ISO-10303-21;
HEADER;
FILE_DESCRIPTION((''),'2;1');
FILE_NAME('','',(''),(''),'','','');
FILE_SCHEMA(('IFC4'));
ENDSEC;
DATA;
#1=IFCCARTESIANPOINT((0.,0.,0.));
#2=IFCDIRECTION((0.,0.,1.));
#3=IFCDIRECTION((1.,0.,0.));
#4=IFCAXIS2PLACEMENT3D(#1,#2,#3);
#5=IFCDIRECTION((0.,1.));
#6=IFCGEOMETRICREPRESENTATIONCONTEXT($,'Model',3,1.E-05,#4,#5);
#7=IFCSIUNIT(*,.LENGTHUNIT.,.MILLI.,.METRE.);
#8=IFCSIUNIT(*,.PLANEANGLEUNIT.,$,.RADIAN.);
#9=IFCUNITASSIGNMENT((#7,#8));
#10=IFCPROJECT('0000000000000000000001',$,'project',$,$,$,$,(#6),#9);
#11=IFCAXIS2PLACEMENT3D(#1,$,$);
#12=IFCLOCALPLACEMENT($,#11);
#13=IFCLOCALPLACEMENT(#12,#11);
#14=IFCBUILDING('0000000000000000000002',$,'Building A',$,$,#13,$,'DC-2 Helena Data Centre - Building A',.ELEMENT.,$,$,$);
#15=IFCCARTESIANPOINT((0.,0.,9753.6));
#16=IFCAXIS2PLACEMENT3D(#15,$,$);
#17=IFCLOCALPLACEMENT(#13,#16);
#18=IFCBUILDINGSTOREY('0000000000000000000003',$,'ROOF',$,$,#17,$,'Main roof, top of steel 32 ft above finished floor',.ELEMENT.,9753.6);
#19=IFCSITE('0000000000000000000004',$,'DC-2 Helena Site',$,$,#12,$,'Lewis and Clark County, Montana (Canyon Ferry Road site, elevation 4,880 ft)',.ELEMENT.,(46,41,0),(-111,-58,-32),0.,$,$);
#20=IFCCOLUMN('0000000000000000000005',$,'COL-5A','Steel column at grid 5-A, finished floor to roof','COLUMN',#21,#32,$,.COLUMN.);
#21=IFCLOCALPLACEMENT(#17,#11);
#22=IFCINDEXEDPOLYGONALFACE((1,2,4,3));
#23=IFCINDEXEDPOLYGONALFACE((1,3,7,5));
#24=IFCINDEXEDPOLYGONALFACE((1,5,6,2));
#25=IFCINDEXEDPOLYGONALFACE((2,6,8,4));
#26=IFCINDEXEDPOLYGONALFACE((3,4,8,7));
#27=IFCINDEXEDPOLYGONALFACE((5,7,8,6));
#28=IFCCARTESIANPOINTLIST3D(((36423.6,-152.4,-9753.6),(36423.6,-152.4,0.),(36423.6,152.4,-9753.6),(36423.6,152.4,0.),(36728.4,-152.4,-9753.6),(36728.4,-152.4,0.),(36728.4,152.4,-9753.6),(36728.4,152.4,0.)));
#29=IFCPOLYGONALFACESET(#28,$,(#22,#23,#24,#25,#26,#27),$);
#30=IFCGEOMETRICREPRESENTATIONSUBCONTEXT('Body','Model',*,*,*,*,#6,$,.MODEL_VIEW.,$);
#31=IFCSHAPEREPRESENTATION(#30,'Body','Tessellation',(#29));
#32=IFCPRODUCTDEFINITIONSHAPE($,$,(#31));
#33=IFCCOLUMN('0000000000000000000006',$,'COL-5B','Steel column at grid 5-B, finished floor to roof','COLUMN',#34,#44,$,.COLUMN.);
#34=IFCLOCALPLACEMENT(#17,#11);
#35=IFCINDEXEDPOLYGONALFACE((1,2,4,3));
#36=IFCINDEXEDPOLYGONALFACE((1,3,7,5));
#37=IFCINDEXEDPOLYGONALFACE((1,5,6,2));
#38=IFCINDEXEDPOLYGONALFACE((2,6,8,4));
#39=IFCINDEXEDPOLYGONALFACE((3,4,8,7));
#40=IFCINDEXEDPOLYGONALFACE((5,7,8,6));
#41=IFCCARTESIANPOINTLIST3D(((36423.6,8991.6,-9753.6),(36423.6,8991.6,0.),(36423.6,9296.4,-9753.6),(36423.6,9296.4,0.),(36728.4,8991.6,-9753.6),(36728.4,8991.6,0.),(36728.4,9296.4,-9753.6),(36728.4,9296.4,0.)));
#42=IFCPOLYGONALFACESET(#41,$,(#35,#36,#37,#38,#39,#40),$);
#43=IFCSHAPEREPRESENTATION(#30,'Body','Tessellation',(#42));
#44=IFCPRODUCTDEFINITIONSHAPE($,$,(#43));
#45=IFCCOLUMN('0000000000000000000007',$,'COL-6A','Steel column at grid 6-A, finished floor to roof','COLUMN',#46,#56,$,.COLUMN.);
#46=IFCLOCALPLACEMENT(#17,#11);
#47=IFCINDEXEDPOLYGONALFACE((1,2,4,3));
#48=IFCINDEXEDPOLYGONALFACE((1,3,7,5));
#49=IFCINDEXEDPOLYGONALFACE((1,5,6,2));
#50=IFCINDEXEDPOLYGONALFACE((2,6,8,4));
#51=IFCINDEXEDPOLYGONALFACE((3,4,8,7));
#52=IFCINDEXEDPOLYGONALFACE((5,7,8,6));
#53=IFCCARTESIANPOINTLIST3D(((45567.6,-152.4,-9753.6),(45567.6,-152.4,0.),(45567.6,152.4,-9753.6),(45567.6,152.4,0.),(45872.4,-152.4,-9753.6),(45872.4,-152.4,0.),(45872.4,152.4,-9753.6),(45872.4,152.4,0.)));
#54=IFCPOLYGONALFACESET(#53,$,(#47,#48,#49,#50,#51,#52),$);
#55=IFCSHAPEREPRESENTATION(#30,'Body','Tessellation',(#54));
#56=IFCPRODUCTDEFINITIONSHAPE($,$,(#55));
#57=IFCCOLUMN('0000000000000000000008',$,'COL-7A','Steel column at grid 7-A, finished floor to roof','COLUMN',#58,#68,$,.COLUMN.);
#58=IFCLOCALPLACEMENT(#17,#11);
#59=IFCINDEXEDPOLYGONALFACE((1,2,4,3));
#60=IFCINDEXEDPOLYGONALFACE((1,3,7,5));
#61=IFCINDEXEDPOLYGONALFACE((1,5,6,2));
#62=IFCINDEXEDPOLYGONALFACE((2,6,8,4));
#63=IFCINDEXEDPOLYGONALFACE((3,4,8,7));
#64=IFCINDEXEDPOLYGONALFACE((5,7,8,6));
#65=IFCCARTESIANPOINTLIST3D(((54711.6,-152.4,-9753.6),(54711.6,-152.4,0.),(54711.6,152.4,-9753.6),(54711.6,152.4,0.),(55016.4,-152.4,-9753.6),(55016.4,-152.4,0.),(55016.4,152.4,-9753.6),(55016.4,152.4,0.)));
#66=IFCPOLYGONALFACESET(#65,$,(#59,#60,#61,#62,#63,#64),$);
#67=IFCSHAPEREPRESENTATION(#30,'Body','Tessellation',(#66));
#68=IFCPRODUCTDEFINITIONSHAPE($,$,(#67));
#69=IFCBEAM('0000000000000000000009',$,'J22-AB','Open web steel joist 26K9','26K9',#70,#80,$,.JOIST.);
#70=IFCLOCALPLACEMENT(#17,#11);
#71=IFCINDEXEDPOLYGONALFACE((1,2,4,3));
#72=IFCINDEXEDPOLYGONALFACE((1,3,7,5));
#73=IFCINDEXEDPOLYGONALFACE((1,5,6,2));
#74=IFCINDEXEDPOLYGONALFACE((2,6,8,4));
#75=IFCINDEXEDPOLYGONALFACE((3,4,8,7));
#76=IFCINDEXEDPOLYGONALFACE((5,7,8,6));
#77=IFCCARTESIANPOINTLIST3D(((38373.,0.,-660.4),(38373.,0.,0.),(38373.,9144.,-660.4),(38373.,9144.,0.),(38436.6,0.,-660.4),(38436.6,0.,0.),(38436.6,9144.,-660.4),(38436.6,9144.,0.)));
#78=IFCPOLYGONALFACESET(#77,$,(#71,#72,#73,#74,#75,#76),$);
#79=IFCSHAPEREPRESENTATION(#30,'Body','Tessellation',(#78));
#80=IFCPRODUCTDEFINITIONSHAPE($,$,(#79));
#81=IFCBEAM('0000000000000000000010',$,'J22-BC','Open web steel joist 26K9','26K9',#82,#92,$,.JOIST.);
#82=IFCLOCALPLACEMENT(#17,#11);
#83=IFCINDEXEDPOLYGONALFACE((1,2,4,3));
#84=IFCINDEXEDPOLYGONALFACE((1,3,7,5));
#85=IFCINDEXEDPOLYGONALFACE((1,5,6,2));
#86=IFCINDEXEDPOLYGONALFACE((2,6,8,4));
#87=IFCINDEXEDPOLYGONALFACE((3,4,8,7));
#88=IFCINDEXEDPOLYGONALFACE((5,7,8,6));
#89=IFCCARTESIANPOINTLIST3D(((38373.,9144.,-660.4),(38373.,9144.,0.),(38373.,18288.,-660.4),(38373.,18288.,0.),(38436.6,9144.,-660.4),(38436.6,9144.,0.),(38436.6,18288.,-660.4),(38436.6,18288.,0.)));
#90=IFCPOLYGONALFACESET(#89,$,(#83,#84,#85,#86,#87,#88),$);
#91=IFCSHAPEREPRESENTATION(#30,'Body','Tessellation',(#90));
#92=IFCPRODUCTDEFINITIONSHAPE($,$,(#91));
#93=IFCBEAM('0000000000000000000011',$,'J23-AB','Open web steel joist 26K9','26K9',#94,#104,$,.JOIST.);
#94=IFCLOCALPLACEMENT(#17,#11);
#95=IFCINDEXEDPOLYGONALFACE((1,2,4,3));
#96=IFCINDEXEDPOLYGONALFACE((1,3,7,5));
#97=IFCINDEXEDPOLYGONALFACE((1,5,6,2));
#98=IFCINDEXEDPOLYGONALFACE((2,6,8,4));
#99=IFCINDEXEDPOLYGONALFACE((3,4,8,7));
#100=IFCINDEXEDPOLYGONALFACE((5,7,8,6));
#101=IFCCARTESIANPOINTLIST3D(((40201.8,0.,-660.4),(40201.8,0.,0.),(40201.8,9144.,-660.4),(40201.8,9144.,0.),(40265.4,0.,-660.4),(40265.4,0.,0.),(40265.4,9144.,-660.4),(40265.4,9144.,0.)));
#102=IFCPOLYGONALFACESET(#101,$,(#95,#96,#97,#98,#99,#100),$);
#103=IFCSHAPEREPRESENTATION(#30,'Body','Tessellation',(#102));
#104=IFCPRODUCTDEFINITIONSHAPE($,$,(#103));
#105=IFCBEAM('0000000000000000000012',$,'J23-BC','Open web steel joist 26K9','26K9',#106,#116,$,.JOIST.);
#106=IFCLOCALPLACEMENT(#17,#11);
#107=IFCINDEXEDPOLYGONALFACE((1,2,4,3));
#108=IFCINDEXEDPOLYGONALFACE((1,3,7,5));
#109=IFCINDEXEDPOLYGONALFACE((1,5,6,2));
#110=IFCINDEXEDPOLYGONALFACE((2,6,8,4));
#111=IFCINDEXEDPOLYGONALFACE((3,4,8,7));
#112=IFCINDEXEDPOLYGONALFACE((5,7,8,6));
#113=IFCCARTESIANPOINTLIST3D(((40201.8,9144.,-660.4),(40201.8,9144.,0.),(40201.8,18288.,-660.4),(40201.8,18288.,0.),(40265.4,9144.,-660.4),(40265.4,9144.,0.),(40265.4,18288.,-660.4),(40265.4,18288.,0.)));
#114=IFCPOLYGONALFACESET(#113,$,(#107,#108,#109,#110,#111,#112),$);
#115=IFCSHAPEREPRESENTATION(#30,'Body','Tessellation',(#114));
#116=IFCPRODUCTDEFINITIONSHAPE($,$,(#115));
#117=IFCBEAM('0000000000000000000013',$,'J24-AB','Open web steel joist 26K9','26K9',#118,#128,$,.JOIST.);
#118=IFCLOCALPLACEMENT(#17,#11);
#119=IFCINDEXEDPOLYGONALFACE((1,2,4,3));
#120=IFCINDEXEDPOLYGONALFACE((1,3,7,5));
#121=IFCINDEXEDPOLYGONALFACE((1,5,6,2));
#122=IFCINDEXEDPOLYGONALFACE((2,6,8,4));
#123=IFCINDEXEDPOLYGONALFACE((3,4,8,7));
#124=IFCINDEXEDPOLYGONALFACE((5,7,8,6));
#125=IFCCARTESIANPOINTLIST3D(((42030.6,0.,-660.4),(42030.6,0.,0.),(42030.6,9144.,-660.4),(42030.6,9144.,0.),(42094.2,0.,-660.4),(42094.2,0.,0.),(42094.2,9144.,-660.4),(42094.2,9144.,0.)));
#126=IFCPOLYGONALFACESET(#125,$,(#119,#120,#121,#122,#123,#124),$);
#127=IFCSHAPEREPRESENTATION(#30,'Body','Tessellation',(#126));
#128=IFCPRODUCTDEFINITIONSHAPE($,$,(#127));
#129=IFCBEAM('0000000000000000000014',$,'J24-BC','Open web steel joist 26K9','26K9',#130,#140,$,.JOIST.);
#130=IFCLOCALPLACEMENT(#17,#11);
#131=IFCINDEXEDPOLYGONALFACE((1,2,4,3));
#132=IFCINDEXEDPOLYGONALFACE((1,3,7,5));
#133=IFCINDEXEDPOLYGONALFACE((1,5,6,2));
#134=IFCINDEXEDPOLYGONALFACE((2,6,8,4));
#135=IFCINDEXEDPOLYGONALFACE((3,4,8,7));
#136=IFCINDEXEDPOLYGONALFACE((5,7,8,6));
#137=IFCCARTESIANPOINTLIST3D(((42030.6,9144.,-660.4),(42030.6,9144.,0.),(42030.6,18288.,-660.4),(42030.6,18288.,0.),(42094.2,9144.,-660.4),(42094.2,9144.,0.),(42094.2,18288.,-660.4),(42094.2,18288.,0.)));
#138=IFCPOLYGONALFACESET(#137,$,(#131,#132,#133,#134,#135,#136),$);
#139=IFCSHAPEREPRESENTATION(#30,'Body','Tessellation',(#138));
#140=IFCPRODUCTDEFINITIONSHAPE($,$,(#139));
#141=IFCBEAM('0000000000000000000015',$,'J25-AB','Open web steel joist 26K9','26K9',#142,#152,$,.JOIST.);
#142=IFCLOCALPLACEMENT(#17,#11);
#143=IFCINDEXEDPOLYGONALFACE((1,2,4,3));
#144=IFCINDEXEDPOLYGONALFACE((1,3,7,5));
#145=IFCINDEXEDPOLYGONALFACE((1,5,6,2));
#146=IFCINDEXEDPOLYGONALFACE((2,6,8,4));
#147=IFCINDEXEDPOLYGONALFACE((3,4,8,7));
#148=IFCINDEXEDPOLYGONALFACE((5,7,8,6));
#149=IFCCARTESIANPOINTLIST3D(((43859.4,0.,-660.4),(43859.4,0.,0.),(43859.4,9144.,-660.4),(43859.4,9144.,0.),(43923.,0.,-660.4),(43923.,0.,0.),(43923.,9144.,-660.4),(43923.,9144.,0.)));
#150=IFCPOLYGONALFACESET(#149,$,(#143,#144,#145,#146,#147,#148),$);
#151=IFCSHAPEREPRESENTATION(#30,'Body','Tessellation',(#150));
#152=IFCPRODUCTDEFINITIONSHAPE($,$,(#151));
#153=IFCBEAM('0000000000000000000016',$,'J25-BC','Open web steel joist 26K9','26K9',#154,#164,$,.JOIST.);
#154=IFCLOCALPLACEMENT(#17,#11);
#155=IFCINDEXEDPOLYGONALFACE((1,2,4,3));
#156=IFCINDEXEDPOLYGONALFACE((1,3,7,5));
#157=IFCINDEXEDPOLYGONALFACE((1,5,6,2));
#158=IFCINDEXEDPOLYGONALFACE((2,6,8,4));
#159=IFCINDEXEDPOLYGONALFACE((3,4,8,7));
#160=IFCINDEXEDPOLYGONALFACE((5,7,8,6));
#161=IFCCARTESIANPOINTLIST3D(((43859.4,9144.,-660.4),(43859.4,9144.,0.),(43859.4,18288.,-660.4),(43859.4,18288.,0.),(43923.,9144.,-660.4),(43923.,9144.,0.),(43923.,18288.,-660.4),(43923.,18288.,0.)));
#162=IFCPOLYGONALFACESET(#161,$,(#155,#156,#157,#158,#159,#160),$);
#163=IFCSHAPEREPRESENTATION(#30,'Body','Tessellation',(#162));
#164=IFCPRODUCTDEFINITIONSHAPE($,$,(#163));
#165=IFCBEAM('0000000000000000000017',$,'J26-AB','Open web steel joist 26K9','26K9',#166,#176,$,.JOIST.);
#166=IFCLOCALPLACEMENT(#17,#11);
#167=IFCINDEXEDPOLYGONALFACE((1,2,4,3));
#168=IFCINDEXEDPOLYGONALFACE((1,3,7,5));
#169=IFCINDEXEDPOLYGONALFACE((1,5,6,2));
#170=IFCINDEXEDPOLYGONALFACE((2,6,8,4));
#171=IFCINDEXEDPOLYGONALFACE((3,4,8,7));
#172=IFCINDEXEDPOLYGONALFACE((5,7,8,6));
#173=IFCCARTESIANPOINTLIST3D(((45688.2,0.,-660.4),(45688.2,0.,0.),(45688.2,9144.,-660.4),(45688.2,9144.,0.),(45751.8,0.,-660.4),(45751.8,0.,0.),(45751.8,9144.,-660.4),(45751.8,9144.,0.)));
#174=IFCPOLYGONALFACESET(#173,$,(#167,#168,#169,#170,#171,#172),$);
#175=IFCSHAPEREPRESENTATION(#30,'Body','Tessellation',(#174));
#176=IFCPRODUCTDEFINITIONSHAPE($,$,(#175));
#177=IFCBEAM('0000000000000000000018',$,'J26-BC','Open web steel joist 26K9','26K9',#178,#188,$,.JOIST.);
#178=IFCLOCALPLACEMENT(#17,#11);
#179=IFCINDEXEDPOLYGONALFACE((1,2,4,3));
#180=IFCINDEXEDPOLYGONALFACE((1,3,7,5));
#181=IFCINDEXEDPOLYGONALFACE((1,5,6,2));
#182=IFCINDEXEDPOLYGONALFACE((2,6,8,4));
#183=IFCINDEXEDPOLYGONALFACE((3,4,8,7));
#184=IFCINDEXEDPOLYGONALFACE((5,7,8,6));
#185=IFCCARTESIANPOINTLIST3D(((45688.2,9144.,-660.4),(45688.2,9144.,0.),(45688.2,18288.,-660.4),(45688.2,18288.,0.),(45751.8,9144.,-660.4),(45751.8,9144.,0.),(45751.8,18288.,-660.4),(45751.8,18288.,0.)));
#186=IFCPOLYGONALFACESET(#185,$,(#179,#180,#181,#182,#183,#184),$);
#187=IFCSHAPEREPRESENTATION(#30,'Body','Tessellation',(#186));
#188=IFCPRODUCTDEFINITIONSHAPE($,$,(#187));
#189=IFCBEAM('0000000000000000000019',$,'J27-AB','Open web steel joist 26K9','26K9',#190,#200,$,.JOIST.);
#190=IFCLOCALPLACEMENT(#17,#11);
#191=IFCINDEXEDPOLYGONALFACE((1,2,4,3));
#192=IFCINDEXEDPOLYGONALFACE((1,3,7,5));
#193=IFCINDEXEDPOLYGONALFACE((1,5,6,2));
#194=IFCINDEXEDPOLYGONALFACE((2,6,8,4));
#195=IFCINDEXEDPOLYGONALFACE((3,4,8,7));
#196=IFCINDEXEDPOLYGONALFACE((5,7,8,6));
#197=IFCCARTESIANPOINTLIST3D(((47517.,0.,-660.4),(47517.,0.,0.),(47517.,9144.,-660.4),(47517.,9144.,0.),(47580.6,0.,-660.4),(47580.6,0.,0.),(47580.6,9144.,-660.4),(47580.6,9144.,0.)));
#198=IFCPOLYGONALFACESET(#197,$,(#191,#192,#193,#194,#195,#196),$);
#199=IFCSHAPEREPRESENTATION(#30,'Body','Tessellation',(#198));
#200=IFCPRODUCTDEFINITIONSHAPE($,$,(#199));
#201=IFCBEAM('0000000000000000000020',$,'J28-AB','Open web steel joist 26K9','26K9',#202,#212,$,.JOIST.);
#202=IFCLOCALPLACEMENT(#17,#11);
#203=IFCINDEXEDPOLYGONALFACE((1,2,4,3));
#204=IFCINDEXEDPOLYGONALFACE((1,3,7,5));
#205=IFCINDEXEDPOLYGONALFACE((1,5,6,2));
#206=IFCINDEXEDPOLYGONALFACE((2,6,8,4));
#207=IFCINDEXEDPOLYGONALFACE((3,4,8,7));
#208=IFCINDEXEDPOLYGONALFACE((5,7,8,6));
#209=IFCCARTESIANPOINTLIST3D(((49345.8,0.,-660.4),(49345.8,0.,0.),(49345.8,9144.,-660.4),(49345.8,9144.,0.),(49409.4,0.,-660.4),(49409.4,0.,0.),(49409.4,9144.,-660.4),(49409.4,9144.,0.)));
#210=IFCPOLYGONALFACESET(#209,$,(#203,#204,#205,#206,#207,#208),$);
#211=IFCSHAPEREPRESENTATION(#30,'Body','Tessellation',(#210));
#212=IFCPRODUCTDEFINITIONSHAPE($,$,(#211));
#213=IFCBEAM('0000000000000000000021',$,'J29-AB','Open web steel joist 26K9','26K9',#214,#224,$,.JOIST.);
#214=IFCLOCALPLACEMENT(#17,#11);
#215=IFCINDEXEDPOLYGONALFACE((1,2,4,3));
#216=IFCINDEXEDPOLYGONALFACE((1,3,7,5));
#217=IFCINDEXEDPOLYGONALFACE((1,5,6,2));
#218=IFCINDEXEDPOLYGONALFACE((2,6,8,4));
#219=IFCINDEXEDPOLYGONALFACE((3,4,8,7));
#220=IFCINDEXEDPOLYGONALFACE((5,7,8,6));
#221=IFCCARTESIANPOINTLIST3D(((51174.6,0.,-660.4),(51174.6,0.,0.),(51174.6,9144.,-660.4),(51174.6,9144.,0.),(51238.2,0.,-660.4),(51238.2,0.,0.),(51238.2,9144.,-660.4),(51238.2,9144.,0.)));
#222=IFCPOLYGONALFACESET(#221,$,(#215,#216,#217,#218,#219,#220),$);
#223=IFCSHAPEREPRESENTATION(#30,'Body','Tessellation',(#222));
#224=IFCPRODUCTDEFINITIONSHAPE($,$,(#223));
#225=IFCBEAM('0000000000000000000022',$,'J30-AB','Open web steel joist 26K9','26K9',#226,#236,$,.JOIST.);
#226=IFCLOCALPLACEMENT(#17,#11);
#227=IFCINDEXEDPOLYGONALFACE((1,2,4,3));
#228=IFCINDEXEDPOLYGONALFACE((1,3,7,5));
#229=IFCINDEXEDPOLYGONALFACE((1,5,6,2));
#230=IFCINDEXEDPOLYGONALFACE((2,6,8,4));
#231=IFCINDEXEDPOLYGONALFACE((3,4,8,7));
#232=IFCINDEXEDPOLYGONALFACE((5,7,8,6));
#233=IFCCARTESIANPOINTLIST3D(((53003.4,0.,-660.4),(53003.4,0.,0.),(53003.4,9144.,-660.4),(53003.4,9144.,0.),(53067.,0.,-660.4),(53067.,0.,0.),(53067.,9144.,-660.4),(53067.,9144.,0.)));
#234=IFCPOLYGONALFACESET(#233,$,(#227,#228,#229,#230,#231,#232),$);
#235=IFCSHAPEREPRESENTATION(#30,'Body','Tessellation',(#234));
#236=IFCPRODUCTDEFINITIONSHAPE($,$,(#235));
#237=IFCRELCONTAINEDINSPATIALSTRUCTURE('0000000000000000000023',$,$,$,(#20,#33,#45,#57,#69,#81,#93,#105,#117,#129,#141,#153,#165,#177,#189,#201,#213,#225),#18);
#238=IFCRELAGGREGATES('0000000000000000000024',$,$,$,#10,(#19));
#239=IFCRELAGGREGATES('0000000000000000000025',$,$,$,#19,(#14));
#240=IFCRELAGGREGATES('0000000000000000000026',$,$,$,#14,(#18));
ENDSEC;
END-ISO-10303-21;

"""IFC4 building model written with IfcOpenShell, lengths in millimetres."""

from ifc_helpers import new_model, si_unit, direction, frame, origin, origin_with_axes, origin_2d, place, context, subcontext, project, spatial, rectangle, extrude, element, save


model = new_model("IFC4")

# Units and contexts
model_context = context("Model", 3, precision=1e-05, world=origin_with_axes(), true_north=direction((0.0, 1.0)))
body_context = subcontext(model_context, "Body", "Model", "MODEL_VIEW")
ifc_project = project(units=[si_unit("LENGTHUNIT", "METRE", prefix="MILLI"), si_unit("PLANEANGLEUNIT", "RADIAN")], contexts=[model_context])

# Site, building, storey
site_placement = place(None, origin())
site = spatial("IfcSite", under=ifc_project, at=site_placement, Name="DC-2 Helena Site", LongName="Lewis and Clark County, Montana (Canyon Ferry Road site, elevation 4,880 ft)", CompositionType="ELEMENT", RefLatitude=(46, 41, 0), RefLongitude=(-111, -58, -32), RefElevation=0.0)
building_placement = place(site_placement, origin())
building = spatial("IfcBuilding", under=site, at=building_placement, Name="Building A", LongName="DC-2 Helena Data Centre - Building A", CompositionType="ELEMENT")
storey_placement = place(building_placement, frame((0.0, 0.0, 9753.6)))
storey = spatial("IfcBuildingStorey", under=building, at=storey_placement, Name="ROOF", LongName="Main roof, top of steel 32 ft above finished floor", CompositionType="ELEMENT", Elevation=9753.6)

# Columns
for number, where, name, description in (
    (1, (36576.0, 0.0, -9753.6), "COL-5A", "Steel column at grid 5-A, finished floor to roof"),
    (2, (36576.0, 9144.0, -9753.6), "COL-5B", "Steel column at grid 5-B, finished floor to roof"),
    (3, (45720.0, 0.0, -9753.6), "COL-6A", "Steel column at grid 6-A, finished floor to roof"),
):
    element("IfcColumn", number, at=place(storey_placement, frame(where)), inside=storey, Name=name, Description=description, ObjectType="COLUMN", PredefinedType="COLUMN", context=body_context, shape_type="SweptSolid", body=[
        extrude(rectangle(XDim=304.8, YDim=304.8, at=origin_2d()), origin(), (0.0, 0.0, 1.0), 9753.6),
    ])
column_placement = place(storey_placement, frame((54864.0, 0.0, -9753.6)))
element("IfcColumn", 4, at=column_placement, inside=storey, Name="COL-7A", Description="Steel column at grid 7-A, finished floor to roof", ObjectType="COLUMN", PredefinedType="COLUMN", context=body_context, shape_type="SweptSolid", body=[
    extrude(rectangle(XDim=304.8, YDim=304.8, at=origin_2d()), origin(), (0.0, 0.0, 1.0), 9753.6),
])

# Beams
for number, where, name in (
    (5, (38404.8, 0.0, 0.0), "J22-AB"),
    (6, (38404.8, 9144.0, 0.0), "J22-BC"),
    (7, (40233.6, 0.0, 0.0), "J23-AB"),
    (8, (40233.6, 9144.0, 0.0), "J23-BC"),
    (9, (42062.4, 0.0, 0.0), "J24-AB"),
    (10, (42062.4, 9144.0, 0.0), "J24-BC"),
    (11, (43891.2, 0.0, 0.0), "J25-AB"),
    (12, (43891.2, 9144.0, 0.0), "J25-BC"),
):
    element("IfcBeam", number, at=place(storey_placement, frame(where)), inside=storey, Name=name, Description="Open web steel joist 26K9", ObjectType="26K9", PredefinedType="JOIST", context=body_context, shape_type="SweptSolid", body=[
        extrude(rectangle(XDim=63.5, YDim=660.4, at=origin_2d()), frame((0.0, 0.0, -330.2), z_axis=(0.0, 1.0, 0.0), x_axis=(1.0, 0.0, 0.0)), (0.0, 0.0, 1.0), 9144.0),
    ])
placement_1 = place(storey_placement, frame((45720.0, 0.0, 0.0)))
element("IfcBeam", 13, at=placement_1, inside=storey, Name="J26-AB", Description="Open web steel joist 26K9", ObjectType="26K9", PredefinedType="JOIST", context=body_context, shape_type="SweptSolid", body=[
    extrude(rectangle(XDim=63.5, YDim=660.4, at=origin_2d()), frame((0.0, 0.0, -330.2), z_axis=(0.0, 1.0, 0.0), x_axis=(1.0, 0.0, 0.0)), (0.0, 0.0, 1.0), 9144.0),
])
placement_2 = place(storey_placement, frame((45720.0, 9144.0, 0.0)))
element("IfcBeam", 14, at=placement_2, inside=storey, Name="J26-BC", Description="Open web steel joist 26K9", ObjectType="26K9", PredefinedType="JOIST", context=body_context, shape_type="SweptSolid", body=[
    extrude(rectangle(XDim=63.5, YDim=660.4, at=origin_2d()), frame((0.0, 0.0, -330.2), z_axis=(0.0, 1.0, 0.0), x_axis=(1.0, 0.0, 0.0)), (0.0, 0.0, 1.0), 9144.0),
])
for number, where, name in (
    (15, (47548.8, 0.0, 0.0), "J27-AB"),
    (16, (49377.6, 0.0, 0.0), "J28-AB"),
    (17, (51206.4, 0.0, 0.0), "J29-AB"),
    (18, (53035.2, 0.0, 0.0), "J30-AB"),
):
    element("IfcBeam", number, at=place(storey_placement, frame(where)), inside=storey, Name=name, Description="Open web steel joist 26K9", ObjectType="26K9", PredefinedType="JOIST", context=body_context, shape_type="SweptSolid", body=[
        extrude(rectangle(XDim=63.5, YDim=660.4, at=origin_2d()), frame((0.0, 0.0, -330.2), z_axis=(0.0, 1.0, 0.0), x_axis=(1.0, 0.0, 0.0)), (0.0, 0.0, 1.0), 9144.0),
    ])

save(model, "model.ifc")
